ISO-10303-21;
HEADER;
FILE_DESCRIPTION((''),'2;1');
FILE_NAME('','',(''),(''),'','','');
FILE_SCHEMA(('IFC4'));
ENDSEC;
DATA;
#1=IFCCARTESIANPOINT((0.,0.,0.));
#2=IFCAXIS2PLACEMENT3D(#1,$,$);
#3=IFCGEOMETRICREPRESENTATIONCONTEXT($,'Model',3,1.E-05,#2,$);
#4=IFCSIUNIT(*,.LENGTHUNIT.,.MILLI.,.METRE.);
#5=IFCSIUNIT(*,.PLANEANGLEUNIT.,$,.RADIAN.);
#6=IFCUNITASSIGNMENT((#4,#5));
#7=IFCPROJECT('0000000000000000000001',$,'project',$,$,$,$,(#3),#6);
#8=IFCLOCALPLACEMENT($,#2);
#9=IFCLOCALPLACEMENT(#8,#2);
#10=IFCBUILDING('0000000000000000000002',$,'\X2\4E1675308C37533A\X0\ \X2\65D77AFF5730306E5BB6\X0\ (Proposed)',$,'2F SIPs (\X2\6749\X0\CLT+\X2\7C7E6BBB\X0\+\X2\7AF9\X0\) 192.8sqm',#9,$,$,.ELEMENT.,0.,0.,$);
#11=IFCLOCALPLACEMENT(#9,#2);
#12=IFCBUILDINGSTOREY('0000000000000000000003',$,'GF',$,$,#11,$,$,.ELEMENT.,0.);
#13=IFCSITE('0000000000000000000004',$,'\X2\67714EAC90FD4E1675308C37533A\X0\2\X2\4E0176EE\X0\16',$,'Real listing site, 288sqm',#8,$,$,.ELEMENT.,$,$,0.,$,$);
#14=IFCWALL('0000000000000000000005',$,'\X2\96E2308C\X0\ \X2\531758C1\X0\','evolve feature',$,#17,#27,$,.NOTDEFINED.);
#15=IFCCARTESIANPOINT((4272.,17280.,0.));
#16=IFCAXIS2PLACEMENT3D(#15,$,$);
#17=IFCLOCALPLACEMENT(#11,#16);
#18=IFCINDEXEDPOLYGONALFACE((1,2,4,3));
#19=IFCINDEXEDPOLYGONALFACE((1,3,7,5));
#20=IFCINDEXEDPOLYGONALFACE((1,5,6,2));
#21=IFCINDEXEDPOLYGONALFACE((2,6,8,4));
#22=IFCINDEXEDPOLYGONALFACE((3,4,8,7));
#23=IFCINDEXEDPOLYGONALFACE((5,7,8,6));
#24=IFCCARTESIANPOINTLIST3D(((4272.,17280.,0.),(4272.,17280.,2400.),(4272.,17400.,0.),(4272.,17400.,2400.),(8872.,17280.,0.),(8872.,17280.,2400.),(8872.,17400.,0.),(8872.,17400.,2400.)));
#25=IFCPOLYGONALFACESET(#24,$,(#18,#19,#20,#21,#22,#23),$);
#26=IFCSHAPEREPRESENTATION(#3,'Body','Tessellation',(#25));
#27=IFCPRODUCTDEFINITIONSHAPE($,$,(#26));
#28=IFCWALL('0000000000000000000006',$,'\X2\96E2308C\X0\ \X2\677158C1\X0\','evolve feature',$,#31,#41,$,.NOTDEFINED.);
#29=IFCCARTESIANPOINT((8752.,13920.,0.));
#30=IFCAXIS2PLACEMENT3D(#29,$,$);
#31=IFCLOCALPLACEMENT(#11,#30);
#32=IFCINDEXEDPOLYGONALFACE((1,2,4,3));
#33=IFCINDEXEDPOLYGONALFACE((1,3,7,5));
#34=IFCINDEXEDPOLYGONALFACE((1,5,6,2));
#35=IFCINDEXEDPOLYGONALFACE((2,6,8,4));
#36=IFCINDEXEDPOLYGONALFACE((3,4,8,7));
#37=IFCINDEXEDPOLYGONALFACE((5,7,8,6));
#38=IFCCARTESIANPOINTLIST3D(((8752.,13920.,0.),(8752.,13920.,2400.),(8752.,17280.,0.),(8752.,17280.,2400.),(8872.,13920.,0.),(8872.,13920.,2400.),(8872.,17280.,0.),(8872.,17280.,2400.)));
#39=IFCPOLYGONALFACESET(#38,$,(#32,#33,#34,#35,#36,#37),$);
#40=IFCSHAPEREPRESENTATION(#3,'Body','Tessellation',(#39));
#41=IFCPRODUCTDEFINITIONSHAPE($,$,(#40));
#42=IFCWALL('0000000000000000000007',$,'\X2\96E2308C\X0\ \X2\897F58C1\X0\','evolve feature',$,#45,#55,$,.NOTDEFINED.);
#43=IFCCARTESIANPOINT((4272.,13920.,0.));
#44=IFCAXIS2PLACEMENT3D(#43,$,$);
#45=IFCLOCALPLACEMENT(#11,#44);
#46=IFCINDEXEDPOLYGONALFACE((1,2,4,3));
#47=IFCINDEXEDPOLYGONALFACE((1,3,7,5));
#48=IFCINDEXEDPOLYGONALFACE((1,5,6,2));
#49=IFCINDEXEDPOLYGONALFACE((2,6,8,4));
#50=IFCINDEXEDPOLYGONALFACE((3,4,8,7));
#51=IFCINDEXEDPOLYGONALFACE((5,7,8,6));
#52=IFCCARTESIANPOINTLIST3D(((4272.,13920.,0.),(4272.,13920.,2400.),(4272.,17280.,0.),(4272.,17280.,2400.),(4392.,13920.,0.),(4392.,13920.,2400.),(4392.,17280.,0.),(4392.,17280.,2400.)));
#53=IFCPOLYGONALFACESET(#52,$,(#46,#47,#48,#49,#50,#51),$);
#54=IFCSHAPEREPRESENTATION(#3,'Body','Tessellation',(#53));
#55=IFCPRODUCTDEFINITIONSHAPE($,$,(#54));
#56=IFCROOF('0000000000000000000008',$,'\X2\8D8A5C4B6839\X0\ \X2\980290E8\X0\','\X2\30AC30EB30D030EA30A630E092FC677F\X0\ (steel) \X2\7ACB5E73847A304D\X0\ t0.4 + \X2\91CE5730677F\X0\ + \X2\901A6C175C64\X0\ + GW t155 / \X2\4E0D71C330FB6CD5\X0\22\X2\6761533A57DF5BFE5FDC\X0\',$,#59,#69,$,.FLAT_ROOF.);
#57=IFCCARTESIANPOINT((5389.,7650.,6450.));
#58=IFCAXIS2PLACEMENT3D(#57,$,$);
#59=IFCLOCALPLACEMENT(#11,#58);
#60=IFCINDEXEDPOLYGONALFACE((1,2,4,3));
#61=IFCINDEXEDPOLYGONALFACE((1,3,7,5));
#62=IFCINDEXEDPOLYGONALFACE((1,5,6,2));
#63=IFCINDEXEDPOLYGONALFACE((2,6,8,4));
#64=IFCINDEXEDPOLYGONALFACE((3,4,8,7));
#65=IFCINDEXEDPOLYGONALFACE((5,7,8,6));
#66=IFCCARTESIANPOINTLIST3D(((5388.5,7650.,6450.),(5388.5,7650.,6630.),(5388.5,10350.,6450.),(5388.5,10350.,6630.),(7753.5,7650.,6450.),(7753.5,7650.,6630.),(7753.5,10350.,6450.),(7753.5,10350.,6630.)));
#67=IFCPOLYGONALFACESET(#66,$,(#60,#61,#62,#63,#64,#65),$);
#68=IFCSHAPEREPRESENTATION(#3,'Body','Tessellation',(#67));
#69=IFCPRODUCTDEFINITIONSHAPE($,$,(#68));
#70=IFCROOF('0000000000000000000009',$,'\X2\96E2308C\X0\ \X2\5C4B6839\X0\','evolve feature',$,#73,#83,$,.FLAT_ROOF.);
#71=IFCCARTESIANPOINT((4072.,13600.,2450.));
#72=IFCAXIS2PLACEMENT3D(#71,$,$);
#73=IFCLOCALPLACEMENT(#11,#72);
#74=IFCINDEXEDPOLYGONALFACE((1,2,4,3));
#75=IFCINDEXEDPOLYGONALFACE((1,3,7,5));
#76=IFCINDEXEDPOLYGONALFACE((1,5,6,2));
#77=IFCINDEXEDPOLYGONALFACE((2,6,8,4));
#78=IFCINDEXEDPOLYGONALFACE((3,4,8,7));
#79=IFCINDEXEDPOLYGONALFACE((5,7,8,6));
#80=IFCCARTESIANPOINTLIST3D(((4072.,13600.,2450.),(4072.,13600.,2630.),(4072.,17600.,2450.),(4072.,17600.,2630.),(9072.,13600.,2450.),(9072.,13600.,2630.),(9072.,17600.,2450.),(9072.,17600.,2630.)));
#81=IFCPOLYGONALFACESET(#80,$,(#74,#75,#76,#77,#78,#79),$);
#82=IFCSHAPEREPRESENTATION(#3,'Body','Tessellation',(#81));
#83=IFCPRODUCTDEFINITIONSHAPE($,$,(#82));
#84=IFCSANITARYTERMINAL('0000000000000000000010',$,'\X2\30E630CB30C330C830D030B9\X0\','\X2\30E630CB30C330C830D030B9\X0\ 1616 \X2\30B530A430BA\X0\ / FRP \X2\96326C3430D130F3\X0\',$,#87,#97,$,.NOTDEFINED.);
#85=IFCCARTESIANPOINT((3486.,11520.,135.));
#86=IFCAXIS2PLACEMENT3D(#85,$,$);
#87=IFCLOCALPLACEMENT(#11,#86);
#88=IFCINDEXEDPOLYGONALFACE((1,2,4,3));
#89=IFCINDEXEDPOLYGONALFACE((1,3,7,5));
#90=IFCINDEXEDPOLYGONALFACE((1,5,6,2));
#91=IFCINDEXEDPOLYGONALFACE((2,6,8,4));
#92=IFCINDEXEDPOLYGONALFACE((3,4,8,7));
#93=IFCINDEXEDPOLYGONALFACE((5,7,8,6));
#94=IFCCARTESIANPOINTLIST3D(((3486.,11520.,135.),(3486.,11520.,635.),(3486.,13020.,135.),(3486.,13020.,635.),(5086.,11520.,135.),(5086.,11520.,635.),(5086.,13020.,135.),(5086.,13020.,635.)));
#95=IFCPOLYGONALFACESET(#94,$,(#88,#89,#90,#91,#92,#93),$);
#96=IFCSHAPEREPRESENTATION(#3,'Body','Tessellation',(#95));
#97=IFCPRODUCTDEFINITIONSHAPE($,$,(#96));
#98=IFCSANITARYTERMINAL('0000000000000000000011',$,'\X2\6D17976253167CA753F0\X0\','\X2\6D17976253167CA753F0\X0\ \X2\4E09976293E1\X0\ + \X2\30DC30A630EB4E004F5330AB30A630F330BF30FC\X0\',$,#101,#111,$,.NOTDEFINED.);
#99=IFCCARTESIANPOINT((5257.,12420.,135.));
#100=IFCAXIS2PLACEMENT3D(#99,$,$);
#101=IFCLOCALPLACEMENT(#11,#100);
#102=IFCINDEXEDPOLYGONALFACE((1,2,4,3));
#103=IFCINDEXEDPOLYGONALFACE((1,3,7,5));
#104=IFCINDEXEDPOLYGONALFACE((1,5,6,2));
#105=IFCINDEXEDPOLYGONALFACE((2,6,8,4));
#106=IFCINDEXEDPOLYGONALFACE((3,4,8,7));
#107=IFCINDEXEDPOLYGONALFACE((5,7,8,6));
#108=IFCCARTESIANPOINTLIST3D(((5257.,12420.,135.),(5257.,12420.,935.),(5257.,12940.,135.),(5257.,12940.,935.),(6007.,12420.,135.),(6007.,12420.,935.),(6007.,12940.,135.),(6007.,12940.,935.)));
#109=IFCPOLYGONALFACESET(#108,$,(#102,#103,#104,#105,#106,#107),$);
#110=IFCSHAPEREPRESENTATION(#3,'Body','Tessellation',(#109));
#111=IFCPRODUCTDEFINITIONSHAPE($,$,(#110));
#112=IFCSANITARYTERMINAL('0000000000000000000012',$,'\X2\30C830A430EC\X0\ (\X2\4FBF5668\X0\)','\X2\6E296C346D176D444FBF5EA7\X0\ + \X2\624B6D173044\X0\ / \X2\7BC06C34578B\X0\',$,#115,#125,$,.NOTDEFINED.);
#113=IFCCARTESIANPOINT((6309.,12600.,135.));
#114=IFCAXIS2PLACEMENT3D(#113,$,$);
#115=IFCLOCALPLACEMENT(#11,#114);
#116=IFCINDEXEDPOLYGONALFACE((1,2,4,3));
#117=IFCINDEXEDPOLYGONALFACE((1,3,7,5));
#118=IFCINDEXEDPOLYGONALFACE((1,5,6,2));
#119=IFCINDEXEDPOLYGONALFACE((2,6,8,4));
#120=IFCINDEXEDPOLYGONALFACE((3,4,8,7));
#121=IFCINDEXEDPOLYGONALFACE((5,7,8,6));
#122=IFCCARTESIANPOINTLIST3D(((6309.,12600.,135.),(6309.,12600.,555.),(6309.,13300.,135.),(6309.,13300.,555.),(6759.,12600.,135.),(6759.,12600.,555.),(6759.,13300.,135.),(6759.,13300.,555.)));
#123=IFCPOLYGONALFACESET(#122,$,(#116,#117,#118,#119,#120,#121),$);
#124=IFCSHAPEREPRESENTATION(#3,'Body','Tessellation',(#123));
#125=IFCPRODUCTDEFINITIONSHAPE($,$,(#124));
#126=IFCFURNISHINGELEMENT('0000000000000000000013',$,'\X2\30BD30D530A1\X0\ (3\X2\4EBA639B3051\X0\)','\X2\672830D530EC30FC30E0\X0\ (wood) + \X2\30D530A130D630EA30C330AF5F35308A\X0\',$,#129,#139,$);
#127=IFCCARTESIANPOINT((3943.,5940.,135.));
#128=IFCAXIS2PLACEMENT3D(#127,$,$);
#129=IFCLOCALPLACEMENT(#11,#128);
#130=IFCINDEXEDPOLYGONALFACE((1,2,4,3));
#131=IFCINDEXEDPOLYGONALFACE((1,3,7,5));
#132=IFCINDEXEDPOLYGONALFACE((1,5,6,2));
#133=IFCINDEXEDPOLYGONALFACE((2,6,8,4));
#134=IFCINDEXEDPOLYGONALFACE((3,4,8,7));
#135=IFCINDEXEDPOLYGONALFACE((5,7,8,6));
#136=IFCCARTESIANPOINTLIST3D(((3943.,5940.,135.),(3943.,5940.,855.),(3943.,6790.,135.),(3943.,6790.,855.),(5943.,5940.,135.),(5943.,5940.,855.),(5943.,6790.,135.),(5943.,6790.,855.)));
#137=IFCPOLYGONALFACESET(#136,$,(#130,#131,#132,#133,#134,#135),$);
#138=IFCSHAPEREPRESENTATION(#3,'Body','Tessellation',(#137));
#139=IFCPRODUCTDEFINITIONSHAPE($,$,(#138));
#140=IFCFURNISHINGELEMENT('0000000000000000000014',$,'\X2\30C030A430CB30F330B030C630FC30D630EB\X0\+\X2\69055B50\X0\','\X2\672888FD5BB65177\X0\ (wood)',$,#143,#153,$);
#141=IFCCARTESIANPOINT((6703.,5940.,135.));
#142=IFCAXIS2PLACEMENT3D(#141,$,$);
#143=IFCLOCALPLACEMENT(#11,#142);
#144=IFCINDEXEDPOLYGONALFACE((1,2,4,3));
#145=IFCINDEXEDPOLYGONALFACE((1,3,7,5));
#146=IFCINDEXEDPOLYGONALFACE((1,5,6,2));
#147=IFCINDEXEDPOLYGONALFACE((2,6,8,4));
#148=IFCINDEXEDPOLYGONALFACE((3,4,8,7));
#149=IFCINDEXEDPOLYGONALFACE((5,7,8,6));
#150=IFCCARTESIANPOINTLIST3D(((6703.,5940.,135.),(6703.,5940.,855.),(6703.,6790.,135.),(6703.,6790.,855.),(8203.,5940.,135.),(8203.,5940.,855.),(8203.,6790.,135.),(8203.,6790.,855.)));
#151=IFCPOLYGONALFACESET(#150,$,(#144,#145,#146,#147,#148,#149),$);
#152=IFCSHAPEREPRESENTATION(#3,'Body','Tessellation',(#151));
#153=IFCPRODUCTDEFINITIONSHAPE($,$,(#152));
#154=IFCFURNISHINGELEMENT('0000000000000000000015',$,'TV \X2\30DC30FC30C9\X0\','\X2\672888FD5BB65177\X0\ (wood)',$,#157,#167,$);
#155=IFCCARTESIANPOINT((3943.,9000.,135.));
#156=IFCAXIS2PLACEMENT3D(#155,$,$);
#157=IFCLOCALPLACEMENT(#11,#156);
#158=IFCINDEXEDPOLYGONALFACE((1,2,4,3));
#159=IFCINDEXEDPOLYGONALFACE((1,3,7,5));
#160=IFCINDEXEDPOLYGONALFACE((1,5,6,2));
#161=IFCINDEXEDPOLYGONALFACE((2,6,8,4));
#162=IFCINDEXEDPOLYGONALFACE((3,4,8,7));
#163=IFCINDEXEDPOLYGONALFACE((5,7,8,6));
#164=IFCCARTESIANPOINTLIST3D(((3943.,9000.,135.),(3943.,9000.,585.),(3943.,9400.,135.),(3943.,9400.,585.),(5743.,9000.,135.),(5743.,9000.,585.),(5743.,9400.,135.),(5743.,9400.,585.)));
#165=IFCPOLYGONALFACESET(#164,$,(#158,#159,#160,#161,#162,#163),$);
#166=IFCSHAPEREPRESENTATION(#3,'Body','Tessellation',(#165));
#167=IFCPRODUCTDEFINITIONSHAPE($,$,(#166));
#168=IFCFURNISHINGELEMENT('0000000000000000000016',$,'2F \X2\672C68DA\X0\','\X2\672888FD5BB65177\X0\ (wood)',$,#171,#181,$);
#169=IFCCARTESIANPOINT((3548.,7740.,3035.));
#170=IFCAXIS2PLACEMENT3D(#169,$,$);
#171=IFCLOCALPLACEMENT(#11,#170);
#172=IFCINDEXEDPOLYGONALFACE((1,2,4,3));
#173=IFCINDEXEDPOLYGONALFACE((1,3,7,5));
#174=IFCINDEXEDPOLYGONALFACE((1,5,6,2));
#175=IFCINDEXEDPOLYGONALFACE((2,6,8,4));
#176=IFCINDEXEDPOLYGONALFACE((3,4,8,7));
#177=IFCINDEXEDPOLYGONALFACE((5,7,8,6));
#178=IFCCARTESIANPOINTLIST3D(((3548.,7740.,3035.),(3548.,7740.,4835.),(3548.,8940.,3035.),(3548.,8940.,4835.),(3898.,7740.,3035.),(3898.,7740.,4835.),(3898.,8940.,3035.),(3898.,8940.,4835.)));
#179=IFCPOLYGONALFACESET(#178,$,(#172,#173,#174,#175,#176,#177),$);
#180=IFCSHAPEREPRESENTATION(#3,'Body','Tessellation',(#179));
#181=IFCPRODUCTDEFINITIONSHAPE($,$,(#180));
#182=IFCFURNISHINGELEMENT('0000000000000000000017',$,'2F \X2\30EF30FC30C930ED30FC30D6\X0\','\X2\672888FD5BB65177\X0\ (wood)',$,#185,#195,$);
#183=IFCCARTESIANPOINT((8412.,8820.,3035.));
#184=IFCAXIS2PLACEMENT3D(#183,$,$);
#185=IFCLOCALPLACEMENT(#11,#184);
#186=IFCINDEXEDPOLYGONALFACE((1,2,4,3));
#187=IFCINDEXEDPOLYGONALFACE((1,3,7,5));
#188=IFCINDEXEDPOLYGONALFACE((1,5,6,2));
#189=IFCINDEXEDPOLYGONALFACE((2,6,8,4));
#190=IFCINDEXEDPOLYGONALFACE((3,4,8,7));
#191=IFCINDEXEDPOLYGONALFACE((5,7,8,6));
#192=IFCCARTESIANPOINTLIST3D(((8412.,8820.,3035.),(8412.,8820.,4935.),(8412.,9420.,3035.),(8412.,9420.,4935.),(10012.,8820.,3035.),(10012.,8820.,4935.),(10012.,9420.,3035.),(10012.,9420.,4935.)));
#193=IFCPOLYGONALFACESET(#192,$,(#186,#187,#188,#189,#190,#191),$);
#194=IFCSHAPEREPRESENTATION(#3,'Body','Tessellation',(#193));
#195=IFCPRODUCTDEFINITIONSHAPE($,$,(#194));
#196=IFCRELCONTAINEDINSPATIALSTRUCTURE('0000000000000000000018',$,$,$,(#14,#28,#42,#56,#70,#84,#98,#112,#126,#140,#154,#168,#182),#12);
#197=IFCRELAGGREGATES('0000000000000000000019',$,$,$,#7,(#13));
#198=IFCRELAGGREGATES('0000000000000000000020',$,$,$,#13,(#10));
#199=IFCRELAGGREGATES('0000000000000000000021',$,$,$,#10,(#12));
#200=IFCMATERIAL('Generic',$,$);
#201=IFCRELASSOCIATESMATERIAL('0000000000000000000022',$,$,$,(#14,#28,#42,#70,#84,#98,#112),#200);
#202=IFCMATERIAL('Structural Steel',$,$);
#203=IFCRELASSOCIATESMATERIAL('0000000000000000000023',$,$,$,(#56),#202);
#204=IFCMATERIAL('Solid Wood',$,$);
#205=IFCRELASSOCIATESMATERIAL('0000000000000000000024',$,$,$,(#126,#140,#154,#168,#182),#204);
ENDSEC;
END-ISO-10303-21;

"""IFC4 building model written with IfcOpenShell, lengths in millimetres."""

from ifc_helpers import new_model, si_unit, frame, frame_2d, origin, place, context, project, spatial, rectangle, extrude, material, element, save


model = new_model("IFC4")

# Units and contexts
model_context = context("Model", 3, precision=1e-05, world=origin())
ifc_project = project(units=[si_unit("LENGTHUNIT", "METRE", prefix="MILLI"), si_unit("PLANEANGLEUNIT", "RADIAN")], contexts=[model_context])

# Site, building, storey
site_placement = place(None, origin())
site = spatial("IfcSite", under=ifc_project, at=site_placement, Name="東京都世田谷区2丁目16", ObjectType="Real listing site, 288sqm", CompositionType="ELEMENT", RefElevation=0.0)
building_placement = place(site_placement, origin())
building = spatial("IfcBuilding", under=site, at=building_placement, Name="世田谷区 旗竿地の家 (Proposed)", ObjectType="2F SIPs (杉CLT+籾殻+竹) 192.8sqm", CompositionType="ELEMENT", ElevationOfRefHeight=0.0, ElevationOfTerrain=0.0)
storey_placement = place(building_placement, origin())
storey = spatial("IfcBuildingStorey", under=building, at=storey_placement, Name="GF", CompositionType="ELEMENT", Elevation=0.0)

# Shared definitions
ifc_material_1 = material(Name="Generic")

# Shared definitions
ifc_material_2 = material(Name="Solid Wood")

# Walls
wall_1_placement = place(storey_placement, frame((4272.0, 17280.0, 0.0)))
element("IfcWall", 1, at=wall_1_placement, inside=storey, material=ifc_material_1, Name="離れ 北壁", Description="evolve feature", PredefinedType="NOTDEFINED", context=model_context, shape_type="SweptSolid", body=[
    extrude(rectangle(XDim=4600.0, YDim=120.0, at=frame_2d((2300.0, 60.0))), frame((4272.0, 17280.0, 0.0)), (0.0, 0.0, 1.0), 2400.0),
])
wall_2_placement = place(storey_placement, frame((8752.0, 13920.0, 0.0)))
element("IfcWall", 2, at=wall_2_placement, inside=storey, material=ifc_material_1, Name="離れ 東壁", Description="evolve feature", PredefinedType="NOTDEFINED", context=model_context, shape_type="SweptSolid", body=[
    extrude(rectangle(XDim=120.0, YDim=3360.0, at=frame_2d((60.0, 1680.0))), frame((8752.0, 13920.0, 0.0)), (0.0, 0.0, 1.0), 2400.0),
])
wall_3_placement = place(storey_placement, frame((4272.0, 13920.0, 0.0)))
element("IfcWall", 3, at=wall_3_placement, inside=storey, material=ifc_material_1, Name="離れ 西壁", Description="evolve feature", PredefinedType="NOTDEFINED", context=model_context, shape_type="SweptSolid", body=[
    extrude(rectangle(XDim=120.0, YDim=3360.0, at=frame_2d((60.0, 1680.0))), frame((4272.0, 13920.0, 0.0)), (0.0, 0.0, 1.0), 2400.0),
])

# Roofs
ifc_material_3 = material(Name="Structural Steel")
roof_1_placement = place(storey_placement, frame((5389.0, 7650.0, 6450.0)))
element("IfcRoof", 4, at=roof_1_placement, inside=storey, material=ifc_material_3, Name="越屋根 頂部", Description="ガルバリウム鋼板 (steel) 立平葺き t0.4 + 野地板 + 通気層 + GW t155 / 不燃・法22条区域対応", PredefinedType="FLAT_ROOF", context=model_context, shape_type="SweptSolid", body=[
    extrude(rectangle(XDim=2365.0, YDim=2700.0, at=frame_2d((1182.0, 1350.0))), frame((5389.0, 7650.0, 6450.0)), (0.0, 0.0, 1.0), 180.0),
])
roof_2_placement = place(storey_placement, frame((4072.0, 13600.0, 2450.0)))
element("IfcRoof", 5, at=roof_2_placement, inside=storey, material=ifc_material_1, Name="離れ 屋根", Description="evolve feature", PredefinedType="FLAT_ROOF", context=model_context, shape_type="SweptSolid", body=[
    extrude(rectangle(XDim=5000.0, YDim=4000.0, at=frame_2d((2500.0, 2000.0))), frame((4072.0, 13600.0, 2450.0)), (0.0, 0.0, 1.0), 180.0),
])

# Sanitary terminals
sanitary_terminal_1_placement = place(storey_placement, frame((3486.0, 11520.0, 135.0)))
element("IfcSanitaryTerminal", 6, at=sanitary_terminal_1_placement, inside=storey, material=ifc_material_1, Name="ユニットバス", Description="ユニットバス 1616 サイズ / FRP 防水パン", PredefinedType="NOTDEFINED", context=model_context, shape_type="SweptSolid", body=[
    extrude(rectangle(XDim=1600.0, YDim=1500.0, at=frame_2d((800.0, 750.0))), frame((3486.0, 11520.0, 135.0)), (0.0, 0.0, 1.0), 500.0),
])
sanitary_terminal_2_placement = place(storey_placement, frame((5257.0, 12420.0, 135.0)))
element("IfcSanitaryTerminal", 7, at=sanitary_terminal_2_placement, inside=storey, material=ifc_material_1, Name="洗面化粧台", Description="洗面化粧台 三面鏡 + ボウル一体カウンター", PredefinedType="NOTDEFINED", context=model_context, shape_type="SweptSolid", body=[
    extrude(rectangle(XDim=750.0, YDim=520.0, at=frame_2d((375.0, 260.0))), frame((5257.0, 12420.0, 135.0)), (0.0, 0.0, 1.0), 800.0),
])
sanitary_terminal_3_placement = place(storey_placement, frame((6309.0, 12600.0, 135.0)))
element("IfcSanitaryTerminal", 8, at=sanitary_terminal_3_placement, inside=storey, material=ifc_material_1, Name="トイレ (便器)", Description="温水洗浄便座 + 手洗い / 節水型", PredefinedType="NOTDEFINED", context=model_context, shape_type="SweptSolid", body=[
    extrude(rectangle(XDim=450.0, YDim=700.0, at=frame_2d((225.0, 350.0))), frame((6309.0, 12600.0, 135.0)), (0.0, 0.0, 1.0), 420.0),
])

# Furnishing elements
furnishing_1_placement = place(storey_placement, frame((3943.0, 5940.0, 135.0)))
element("IfcFurnishingElement", 9, at=furnishing_1_placement, inside=storey, material=ifc_material_2, Name="ソファ (3人掛け)", Description="木フレーム (wood) + ファブリック張り", context=model_context, shape_type="SweptSolid", body=[
    extrude(rectangle(XDim=2000.0, YDim=850.0, at=frame_2d((1000.0, 425.0))), frame((3943.0, 5940.0, 135.0)), (0.0, 0.0, 1.0), 720.0),
])
furnishing_2_placement = place(storey_placement, frame((6703.0, 5940.0, 135.0)))
element("IfcFurnishingElement", 10, at=furnishing_2_placement, inside=storey, material=ifc_material_2, Name="ダイニングテーブル+椅子", Description="木製家具 (wood)", context=model_context, shape_type="SweptSolid", body=[
    extrude(rectangle(XDim=1500.0, YDim=850.0, at=frame_2d((750.0, 425.0))), frame((6703.0, 5940.0, 135.0)), (0.0, 0.0, 1.0), 720.0),
])
furnishing_3_placement = place(storey_placement, frame((3943.0, 9000.0, 135.0)))
element("IfcFurnishingElement", 11, at=furnishing_3_placement, inside=storey, material=ifc_material_2, Name="TV ボード", Description="木製家具 (wood)", context=model_context, shape_type="SweptSolid", body=[
    extrude(rectangle(XDim=1800.0, YDim=400.0, at=frame_2d((900.0, 200.0))), frame((3943.0, 9000.0, 135.0)), (0.0, 0.0, 1.0), 450.0),
])
furnishing_4_placement = place(storey_placement, frame((3548.0, 7740.0, 3035.0)))
element("IfcFurnishingElement", 12, at=furnishing_4_placement, inside=storey, material=ifc_material_2, Name="2F 本棚", Description="木製家具 (wood)", context=model_context, shape_type="SweptSolid", body=[
    extrude(rectangle(XDim=350.0, YDim=1200.0, at=frame_2d((175.0, 600.0))), frame((3548.0, 7740.0, 3035.0)), (0.0, 0.0, 1.0), 1800.0),
])
furnishing_5_placement = place(storey_placement, frame((8412.0, 8820.0, 3035.0)))
element("IfcFurnishingElement", 13, at=furnishing_5_placement, inside=storey, material=ifc_material_2, Name="2F ワードローブ", Description="木製家具 (wood)", context=model_context, shape_type="SweptSolid", body=[
    extrude(rectangle(XDim=1600.0, YDim=600.0, at=frame_2d((800.0, 300.0))), frame((8412.0, 8820.0, 3035.0)), (0.0, 0.0, 1.0), 1900.0),
])

save(model, "model.ifc")
